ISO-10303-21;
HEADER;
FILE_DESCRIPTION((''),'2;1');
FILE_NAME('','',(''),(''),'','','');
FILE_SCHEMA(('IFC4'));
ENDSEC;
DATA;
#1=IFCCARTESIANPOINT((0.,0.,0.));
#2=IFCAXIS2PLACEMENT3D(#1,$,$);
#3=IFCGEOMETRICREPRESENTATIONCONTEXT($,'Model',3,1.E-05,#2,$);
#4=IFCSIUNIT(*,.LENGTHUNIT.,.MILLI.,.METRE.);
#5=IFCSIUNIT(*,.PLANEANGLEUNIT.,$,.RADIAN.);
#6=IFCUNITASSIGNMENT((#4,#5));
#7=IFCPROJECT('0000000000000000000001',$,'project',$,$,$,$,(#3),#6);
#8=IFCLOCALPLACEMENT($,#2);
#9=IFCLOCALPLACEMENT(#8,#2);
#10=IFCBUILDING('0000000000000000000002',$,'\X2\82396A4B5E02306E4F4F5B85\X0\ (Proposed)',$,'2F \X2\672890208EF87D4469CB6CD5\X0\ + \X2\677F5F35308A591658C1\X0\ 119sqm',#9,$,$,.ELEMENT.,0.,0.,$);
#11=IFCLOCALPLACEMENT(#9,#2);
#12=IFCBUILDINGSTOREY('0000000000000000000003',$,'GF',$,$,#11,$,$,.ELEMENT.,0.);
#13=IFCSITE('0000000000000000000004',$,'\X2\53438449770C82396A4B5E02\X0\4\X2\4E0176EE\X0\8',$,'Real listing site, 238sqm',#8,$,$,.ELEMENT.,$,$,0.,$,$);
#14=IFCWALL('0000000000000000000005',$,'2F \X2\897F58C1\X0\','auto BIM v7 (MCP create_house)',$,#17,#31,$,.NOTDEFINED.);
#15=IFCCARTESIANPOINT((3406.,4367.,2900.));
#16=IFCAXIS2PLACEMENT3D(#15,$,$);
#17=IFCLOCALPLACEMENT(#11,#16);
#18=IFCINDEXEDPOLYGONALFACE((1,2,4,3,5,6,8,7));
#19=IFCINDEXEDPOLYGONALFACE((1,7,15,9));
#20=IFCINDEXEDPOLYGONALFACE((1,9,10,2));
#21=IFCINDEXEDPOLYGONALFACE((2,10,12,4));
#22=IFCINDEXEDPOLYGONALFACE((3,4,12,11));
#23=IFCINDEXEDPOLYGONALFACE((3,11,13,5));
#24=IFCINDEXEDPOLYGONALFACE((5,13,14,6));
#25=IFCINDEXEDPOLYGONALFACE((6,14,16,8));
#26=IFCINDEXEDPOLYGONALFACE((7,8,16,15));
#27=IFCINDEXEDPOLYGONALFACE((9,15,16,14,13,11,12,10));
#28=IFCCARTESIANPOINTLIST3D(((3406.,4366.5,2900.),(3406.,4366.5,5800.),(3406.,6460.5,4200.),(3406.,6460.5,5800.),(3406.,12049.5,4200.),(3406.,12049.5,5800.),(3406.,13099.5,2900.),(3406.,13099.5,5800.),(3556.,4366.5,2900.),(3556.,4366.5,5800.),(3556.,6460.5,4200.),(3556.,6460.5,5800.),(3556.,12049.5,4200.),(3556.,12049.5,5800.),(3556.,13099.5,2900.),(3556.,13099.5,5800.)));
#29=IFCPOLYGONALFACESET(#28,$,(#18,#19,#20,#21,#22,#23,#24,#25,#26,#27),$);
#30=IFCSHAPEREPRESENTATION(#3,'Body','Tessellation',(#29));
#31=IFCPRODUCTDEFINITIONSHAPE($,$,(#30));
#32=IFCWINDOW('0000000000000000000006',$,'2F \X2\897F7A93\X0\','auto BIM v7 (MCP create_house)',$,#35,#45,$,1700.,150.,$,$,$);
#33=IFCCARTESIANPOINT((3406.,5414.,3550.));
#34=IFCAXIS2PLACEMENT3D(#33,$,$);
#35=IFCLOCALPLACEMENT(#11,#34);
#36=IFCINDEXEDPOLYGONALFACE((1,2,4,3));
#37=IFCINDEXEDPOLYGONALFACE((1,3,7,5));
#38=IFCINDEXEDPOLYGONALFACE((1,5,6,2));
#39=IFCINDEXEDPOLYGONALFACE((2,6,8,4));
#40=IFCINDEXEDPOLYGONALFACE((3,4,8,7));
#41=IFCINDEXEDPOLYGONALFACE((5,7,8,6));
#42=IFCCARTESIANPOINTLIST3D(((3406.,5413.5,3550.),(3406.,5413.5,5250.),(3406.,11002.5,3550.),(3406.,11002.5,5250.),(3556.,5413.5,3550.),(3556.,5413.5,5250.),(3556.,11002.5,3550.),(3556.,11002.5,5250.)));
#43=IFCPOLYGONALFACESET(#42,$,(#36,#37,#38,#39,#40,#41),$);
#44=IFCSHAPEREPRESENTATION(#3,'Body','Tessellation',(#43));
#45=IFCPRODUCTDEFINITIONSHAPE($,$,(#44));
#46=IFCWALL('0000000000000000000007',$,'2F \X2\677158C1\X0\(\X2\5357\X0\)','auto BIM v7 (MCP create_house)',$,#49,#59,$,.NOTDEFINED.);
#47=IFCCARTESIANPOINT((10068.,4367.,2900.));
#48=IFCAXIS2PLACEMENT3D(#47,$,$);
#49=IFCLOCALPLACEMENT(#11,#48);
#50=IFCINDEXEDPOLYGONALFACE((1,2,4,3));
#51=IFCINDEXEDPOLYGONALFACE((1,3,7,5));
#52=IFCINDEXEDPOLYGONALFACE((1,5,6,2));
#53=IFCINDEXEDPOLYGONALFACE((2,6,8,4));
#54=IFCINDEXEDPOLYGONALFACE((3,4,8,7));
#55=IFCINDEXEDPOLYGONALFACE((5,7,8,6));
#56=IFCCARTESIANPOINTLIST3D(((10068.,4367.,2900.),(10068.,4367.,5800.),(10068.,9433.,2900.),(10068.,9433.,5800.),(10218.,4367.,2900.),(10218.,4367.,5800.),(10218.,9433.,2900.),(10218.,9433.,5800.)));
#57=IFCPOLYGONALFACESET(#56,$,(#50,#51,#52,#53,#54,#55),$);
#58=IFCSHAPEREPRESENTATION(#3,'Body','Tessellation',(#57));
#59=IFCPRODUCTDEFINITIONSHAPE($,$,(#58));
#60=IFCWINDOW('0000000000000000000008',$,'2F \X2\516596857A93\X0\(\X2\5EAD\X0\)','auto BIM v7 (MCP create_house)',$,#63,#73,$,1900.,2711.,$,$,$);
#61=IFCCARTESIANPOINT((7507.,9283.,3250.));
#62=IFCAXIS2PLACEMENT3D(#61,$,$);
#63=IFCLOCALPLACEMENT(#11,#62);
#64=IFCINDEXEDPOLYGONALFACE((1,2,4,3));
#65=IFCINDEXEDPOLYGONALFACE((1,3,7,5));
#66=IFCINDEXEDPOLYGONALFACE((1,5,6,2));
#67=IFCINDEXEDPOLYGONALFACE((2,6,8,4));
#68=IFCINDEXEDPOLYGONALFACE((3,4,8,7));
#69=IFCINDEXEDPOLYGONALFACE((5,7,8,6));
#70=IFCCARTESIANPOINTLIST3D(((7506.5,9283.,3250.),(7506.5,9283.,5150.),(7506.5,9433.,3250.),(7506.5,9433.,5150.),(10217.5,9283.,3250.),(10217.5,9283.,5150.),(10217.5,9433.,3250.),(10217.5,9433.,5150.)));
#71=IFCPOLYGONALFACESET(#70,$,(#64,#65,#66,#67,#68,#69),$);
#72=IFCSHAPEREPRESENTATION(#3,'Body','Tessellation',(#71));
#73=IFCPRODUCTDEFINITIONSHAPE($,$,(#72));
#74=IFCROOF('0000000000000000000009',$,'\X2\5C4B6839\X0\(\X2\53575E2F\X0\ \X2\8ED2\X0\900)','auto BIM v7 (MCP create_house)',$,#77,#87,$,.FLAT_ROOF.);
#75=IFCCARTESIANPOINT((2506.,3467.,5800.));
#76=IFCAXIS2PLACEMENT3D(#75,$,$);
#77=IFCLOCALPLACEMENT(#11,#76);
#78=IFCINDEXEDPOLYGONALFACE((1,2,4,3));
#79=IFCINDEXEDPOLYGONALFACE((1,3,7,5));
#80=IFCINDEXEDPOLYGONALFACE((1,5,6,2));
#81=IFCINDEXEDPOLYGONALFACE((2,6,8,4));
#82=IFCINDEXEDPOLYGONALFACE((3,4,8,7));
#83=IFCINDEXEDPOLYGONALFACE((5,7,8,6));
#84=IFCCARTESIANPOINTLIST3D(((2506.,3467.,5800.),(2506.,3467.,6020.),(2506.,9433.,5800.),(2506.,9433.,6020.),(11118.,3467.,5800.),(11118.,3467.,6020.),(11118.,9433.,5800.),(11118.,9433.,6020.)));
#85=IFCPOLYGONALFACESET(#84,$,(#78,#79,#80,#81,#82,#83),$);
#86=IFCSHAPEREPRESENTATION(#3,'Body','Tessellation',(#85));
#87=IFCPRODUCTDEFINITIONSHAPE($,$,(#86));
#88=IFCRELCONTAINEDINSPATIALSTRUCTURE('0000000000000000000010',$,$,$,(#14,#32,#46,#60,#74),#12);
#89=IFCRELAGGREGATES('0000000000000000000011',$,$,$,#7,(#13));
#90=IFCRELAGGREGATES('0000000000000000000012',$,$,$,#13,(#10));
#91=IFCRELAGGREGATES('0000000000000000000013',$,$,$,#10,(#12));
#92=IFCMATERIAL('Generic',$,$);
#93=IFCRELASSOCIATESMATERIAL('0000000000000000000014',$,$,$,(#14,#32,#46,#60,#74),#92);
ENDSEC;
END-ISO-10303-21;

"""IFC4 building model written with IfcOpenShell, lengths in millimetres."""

from ifc_helpers import new_model, si_unit, frame, frame_2d, origin, place, context, project, spatial, rectangle, extrude, material, element, fill, save


model = new_model("IFC4")

# Units and contexts
model_context = context("Model", 3, precision=1e-05, world=origin())
ifc_project = project(units=[si_unit("LENGTHUNIT", "METRE", prefix="MILLI"), si_unit("PLANEANGLEUNIT", "RADIAN")], contexts=[model_context])

# Site, building, storey
site_placement = place(None, origin())
site = spatial("IfcSite", under=ifc_project, at=site_placement, Name="千葉県船橋市4丁目8", ObjectType="Real listing site, 238sqm", CompositionType="ELEMENT", RefElevation=0.0)
building_placement = place(site_placement, origin())
building = spatial("IfcBuilding", under=site, at=building_placement, Name="船橋市の住宅 (Proposed)", ObjectType="2F 木造軸組構法 + 板張り外壁 119sqm", CompositionType="ELEMENT", ElevationOfRefHeight=0.0, ElevationOfTerrain=0.0)
storey_placement = place(building_placement, origin())
storey = spatial("IfcBuildingStorey", under=building, at=storey_placement, Name="GF", CompositionType="ELEMENT", Elevation=0.0)

# Shared definitions
ifc_material = material(Name="Generic")

# Walls, openings, windows
wall_1_placement = place(storey_placement, frame((3406.0, 4367.0, 2900.0)))
wall_1 = element("IfcWall", 1, at=wall_1_placement, inside=storey, material=ifc_material, Name="2F 西壁", Description="auto BIM v7 (MCP create_house)", PredefinedType="NOTDEFINED", context=model_context, shape_type="SweptSolid", body=[
    extrude(rectangle(XDim=150.0, YDim=8733.0, at=frame_2d((75.0, 4366.0))), frame((3406.0, 4367.0, 2900.0)), (0.0, 0.0, 1.0), 2900.0),
])
opening_1_placement = place(storey_placement, frame((3406.0, 5414.0, 3550.0)))
opening_1 = element("IfcOpeningElement", 2, at=opening_1_placement, cuts=wall_1, PredefinedType="NOTDEFINED", context=model_context, shape_type="SweptSolid", body=[
    extrude(rectangle(XDim=150.0, YDim=5589.0, at=frame_2d((75.0, 2794.0))), frame((3406.0, 5414.0, 3550.0)), (0.0, 0.0, 1.0), 1700.0),
])
window_1_placement = place(storey_placement, frame((3406.0, 5414.0, 3550.0)))
window_1 = element("IfcWindow", 3, at=window_1_placement, inside=storey, material=ifc_material, Name="2F 西窓", Description="auto BIM v7 (MCP create_house)", OverallHeight=1700.0, OverallWidth=150.0, context=model_context, shape_type="SweptSolid", body=[
    extrude(rectangle(XDim=150.0, YDim=5589.0, at=frame_2d((75.0, 2794.0))), frame((3406.0, 5414.0, 3550.0)), (0.0, 0.0, 1.0), 1700.0),
])
fill(opening_1, window_1)
wall_2_placement = place(storey_placement, frame((10068.0, 4367.0, 2900.0)))
wall_2 = element("IfcWall", 4, at=wall_2_placement, inside=storey, material=ifc_material, Name="2F 東壁(南)", Description="auto BIM v7 (MCP create_house)", PredefinedType="NOTDEFINED", context=model_context, shape_type="SweptSolid", body=[
    extrude(rectangle(XDim=150.0, YDim=5066.0, at=frame_2d((75.0, 2533.0))), frame((10068.0, 4367.0, 2900.0)), (0.0, 0.0, 1.0), 2900.0),
])
opening_2_placement = place(storey_placement, frame((7507.0, 9283.0, 3250.0)))
opening_2 = element("IfcOpeningElement", 5, at=opening_2_placement, cuts=wall_2, PredefinedType="NOTDEFINED", context=model_context, shape_type="SweptSolid", body=[
    extrude(rectangle(XDim=2711.0, YDim=150.0, at=frame_2d((1355.0, 75.0))), frame((7507.0, 9283.0, 3250.0)), (0.0, 0.0, 1.0), 1900.0),
])
window_2_placement = place(storey_placement, frame((7507.0, 9283.0, 3250.0)))
window_2 = element("IfcWindow", 6, at=window_2_placement, inside=storey, material=ifc_material, Name="2F 入隅窓(庭)", Description="auto BIM v7 (MCP create_house)", OverallHeight=1900.0, OverallWidth=2711.0, context=model_context, shape_type="SweptSolid", body=[
    extrude(rectangle(XDim=2711.0, YDim=150.0, at=frame_2d((1355.0, 75.0))), frame((7507.0, 9283.0, 3250.0)), (0.0, 0.0, 1.0), 1900.0),
])
fill(opening_2, window_2)

# Roof
for number, where, name in (
    (7, (2506.0, 3467.0, 5800.0), "屋根(南帯 軒900)"),
):
    element("IfcRoof", number, at=place(storey_placement, frame(where)), inside=storey, material=ifc_material, Name=name, Description="auto BIM v7 (MCP create_house)", PredefinedType="FLAT_ROOF", context=model_context, shape_type="SweptSolid", body=[
        extrude(rectangle(XDim=8612.0, YDim=5966.0, at=frame_2d((4306.0, 2983.0))), frame((2506.0, 3467.0, 5800.0)), (0.0, 0.0, 1.0), 220.0),
    ])

save(model, "model.ifc")
